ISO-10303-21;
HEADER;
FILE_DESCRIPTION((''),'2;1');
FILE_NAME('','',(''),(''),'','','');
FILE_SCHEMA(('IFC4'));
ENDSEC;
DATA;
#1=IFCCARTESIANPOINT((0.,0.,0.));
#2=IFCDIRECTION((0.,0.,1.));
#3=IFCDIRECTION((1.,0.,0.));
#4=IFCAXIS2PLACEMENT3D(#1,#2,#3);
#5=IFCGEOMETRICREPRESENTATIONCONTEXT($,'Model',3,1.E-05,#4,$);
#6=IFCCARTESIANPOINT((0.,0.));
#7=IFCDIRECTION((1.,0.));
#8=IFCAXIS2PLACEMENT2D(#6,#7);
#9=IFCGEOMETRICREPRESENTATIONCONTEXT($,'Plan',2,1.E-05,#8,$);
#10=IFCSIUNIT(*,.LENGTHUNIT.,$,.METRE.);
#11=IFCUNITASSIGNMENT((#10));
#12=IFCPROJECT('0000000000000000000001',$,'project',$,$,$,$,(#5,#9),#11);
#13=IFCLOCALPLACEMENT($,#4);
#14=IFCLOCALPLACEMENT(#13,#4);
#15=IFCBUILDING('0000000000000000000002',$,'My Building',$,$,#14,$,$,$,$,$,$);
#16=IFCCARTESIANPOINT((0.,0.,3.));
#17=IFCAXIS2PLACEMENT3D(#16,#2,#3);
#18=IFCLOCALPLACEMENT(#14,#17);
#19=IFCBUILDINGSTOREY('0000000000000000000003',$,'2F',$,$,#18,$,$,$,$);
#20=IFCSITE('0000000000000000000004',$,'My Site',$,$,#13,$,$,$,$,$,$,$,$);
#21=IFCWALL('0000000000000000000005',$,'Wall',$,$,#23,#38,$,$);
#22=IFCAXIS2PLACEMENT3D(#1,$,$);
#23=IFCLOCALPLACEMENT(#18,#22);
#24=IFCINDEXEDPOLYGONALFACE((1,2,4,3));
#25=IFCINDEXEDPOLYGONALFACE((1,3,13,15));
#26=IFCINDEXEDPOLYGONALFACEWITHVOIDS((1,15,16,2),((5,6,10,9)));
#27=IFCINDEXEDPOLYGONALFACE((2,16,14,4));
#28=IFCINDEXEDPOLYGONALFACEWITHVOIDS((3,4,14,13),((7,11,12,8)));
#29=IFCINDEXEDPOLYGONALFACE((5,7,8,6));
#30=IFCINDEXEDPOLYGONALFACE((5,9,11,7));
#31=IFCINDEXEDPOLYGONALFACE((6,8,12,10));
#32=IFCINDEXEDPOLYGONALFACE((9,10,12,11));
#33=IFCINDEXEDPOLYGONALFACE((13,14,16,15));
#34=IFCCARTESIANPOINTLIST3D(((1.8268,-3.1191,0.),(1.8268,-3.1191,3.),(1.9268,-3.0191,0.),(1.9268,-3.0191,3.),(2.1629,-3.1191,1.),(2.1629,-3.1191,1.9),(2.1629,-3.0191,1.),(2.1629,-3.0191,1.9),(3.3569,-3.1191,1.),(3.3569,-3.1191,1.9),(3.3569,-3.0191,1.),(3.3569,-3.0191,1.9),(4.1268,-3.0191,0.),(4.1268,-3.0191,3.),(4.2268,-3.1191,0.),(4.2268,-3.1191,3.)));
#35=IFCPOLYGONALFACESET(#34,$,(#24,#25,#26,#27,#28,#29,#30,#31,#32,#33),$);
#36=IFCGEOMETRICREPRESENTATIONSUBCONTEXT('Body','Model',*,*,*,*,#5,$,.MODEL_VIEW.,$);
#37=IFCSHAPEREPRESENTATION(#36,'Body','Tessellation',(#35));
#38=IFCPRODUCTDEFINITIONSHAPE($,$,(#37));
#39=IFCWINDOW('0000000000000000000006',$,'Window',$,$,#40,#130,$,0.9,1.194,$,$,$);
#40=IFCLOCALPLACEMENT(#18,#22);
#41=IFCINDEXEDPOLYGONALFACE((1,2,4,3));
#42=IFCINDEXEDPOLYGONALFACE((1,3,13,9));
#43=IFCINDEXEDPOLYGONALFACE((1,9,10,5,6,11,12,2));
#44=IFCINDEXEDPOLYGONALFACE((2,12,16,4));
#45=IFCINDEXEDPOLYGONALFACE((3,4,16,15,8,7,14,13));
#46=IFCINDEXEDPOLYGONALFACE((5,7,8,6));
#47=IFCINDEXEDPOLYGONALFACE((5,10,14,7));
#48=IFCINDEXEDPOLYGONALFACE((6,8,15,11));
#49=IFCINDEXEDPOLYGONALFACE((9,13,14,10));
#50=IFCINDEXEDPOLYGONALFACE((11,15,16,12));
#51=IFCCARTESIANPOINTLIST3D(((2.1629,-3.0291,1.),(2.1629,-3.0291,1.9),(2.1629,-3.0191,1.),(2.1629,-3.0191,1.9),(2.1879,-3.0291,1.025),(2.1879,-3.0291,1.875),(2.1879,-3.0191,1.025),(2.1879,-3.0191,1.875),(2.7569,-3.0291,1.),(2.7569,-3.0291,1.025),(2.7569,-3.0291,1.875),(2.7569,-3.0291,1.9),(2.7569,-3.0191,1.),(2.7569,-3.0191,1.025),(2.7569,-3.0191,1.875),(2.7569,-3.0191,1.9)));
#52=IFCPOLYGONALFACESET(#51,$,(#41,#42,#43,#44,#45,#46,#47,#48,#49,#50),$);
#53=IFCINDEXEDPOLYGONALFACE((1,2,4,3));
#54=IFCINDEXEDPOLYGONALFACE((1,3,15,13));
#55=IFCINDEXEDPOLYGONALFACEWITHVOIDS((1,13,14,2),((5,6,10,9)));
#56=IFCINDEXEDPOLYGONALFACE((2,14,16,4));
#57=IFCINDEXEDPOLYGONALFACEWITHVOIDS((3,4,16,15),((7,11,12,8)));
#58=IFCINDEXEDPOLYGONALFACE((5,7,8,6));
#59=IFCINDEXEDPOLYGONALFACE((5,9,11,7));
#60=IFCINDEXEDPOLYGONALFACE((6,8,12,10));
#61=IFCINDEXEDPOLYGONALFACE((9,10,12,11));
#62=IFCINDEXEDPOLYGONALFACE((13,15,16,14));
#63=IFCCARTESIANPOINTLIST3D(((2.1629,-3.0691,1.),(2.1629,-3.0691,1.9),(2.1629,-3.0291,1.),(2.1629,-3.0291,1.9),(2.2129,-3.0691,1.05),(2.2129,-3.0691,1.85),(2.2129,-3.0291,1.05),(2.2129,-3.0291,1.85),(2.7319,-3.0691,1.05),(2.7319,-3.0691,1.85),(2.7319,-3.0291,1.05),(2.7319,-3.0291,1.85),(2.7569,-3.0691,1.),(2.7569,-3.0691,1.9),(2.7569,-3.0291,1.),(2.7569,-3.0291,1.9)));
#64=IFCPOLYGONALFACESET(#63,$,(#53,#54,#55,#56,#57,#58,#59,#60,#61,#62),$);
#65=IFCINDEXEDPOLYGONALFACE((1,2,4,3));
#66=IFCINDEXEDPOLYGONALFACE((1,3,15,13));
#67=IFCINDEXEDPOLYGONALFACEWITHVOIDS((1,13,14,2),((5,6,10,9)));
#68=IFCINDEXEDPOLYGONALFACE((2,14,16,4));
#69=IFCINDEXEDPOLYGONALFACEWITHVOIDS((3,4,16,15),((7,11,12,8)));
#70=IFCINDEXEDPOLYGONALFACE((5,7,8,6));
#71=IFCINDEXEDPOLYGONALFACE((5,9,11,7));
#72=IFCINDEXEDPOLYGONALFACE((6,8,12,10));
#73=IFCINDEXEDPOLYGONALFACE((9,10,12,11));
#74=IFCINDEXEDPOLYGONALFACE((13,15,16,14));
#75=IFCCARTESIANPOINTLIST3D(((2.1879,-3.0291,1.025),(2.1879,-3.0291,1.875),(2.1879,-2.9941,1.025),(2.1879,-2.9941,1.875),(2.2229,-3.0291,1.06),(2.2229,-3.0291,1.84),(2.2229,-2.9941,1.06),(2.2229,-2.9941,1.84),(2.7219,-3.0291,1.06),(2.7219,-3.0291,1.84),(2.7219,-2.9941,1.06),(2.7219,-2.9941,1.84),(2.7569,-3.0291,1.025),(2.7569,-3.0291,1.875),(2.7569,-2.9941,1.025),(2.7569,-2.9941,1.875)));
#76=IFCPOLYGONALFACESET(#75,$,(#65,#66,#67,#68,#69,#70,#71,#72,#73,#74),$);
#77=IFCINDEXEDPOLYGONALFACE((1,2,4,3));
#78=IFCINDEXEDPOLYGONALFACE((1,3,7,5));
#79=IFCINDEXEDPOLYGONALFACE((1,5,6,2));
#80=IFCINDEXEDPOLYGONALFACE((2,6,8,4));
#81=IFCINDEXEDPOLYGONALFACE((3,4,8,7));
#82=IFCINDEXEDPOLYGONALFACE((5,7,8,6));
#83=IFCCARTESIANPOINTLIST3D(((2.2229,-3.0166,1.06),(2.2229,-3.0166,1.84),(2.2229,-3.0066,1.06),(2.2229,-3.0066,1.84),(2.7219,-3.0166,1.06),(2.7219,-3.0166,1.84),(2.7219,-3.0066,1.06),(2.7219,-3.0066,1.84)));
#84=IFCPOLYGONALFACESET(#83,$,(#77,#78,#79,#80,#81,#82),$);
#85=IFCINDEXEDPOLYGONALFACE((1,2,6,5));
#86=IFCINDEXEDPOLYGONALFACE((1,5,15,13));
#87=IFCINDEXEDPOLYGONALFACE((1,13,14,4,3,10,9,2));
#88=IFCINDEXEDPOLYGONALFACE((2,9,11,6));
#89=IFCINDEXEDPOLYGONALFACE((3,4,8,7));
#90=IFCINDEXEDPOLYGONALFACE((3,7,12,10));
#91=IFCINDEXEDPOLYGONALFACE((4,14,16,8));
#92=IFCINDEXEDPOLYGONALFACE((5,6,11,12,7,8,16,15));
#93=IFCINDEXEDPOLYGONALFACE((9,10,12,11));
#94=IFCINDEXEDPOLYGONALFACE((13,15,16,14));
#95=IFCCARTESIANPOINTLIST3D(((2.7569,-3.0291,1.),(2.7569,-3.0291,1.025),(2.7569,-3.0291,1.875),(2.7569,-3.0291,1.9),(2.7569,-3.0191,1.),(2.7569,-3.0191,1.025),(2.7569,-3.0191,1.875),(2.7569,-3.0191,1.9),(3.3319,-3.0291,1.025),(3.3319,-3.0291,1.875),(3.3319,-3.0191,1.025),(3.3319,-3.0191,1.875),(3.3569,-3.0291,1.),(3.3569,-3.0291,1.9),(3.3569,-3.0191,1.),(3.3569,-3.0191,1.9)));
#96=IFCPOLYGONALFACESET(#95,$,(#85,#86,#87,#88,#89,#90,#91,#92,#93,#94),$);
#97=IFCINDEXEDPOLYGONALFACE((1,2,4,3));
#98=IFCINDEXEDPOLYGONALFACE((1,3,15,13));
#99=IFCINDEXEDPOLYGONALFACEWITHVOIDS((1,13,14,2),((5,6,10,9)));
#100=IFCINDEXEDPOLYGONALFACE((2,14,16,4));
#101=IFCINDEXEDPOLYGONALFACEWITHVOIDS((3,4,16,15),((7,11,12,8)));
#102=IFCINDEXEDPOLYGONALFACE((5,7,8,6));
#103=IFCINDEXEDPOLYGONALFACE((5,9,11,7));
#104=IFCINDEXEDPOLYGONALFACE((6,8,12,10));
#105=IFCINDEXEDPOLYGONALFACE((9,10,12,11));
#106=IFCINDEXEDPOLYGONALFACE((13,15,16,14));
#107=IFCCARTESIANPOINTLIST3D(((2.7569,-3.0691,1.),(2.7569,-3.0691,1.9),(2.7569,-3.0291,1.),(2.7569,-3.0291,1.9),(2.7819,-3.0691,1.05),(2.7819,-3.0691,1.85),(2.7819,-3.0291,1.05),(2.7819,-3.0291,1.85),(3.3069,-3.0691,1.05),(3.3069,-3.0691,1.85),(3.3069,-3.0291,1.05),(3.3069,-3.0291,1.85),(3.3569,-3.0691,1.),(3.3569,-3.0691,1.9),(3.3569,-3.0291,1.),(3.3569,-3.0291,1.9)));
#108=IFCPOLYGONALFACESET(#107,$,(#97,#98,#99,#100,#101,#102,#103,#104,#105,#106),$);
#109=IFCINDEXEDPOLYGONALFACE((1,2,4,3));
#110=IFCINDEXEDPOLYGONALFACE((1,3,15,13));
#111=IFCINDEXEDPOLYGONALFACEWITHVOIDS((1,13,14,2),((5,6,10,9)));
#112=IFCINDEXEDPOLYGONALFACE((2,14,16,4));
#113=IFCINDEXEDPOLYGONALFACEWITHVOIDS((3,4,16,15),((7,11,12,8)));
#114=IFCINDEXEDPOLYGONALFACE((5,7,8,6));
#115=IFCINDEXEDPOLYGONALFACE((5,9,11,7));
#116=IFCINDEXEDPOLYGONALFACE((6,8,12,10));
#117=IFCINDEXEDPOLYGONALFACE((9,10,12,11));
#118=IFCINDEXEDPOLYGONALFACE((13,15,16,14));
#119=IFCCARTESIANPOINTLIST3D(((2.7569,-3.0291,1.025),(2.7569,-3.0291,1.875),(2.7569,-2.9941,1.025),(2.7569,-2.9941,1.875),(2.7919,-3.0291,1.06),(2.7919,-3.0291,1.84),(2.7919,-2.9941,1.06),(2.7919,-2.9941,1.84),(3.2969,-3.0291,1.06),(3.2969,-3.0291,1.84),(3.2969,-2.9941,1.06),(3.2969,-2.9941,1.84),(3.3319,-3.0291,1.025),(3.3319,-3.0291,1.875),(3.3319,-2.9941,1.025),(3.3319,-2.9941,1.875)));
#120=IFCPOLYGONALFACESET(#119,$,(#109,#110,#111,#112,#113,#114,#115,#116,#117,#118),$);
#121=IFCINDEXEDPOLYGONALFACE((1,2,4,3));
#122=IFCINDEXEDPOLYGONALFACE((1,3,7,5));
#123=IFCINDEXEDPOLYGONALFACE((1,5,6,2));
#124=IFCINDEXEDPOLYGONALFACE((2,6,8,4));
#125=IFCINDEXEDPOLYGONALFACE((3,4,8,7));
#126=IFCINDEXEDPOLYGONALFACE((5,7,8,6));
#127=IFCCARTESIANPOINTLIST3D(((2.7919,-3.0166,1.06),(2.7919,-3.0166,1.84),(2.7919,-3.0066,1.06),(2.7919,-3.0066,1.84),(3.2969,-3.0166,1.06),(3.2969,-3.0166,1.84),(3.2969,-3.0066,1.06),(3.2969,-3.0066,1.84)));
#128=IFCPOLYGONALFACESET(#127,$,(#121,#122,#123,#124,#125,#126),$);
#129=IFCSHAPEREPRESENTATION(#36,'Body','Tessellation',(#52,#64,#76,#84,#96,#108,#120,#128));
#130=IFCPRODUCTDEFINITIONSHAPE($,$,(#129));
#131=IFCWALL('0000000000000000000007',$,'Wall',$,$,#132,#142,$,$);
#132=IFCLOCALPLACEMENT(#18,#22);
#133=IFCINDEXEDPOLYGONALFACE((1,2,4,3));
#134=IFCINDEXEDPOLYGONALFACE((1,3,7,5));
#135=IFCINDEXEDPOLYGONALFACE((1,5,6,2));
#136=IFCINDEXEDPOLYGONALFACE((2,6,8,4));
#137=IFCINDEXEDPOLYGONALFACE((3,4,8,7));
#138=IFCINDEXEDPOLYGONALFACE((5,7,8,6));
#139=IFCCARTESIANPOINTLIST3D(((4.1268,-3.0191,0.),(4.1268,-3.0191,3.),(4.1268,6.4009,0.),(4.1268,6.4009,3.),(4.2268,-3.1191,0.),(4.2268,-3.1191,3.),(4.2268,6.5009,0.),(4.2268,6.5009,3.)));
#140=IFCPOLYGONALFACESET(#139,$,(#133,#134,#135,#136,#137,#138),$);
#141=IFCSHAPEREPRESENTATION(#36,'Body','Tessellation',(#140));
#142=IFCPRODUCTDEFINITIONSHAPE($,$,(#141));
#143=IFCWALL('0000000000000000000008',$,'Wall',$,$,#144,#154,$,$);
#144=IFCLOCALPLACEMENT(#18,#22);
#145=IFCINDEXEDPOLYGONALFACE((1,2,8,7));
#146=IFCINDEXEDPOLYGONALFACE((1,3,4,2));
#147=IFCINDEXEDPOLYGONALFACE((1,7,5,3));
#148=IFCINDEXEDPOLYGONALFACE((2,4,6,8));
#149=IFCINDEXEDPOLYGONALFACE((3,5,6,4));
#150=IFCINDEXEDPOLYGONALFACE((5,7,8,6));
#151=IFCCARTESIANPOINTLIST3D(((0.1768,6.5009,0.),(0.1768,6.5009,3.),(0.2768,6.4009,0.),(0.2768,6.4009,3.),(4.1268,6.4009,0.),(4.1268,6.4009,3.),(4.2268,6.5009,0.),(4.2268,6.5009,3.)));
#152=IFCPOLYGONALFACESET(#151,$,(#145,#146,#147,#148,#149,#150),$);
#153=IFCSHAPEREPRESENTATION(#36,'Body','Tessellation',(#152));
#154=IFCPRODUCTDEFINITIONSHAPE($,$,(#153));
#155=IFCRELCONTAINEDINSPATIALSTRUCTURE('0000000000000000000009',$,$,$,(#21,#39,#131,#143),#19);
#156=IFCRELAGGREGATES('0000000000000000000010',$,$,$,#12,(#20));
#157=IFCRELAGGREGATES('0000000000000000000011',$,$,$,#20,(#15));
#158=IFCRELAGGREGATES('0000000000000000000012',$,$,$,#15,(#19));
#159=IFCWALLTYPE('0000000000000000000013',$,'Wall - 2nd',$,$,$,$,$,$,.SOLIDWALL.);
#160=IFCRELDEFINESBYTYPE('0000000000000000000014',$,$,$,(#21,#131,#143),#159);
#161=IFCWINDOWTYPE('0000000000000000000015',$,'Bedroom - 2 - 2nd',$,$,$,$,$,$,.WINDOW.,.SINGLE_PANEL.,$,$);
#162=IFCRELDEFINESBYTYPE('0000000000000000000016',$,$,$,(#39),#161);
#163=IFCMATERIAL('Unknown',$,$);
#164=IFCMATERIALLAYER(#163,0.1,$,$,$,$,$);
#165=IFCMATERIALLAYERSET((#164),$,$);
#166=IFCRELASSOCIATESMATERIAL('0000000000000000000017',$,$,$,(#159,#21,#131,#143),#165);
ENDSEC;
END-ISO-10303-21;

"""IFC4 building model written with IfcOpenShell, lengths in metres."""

from ifc_helpers import new_model, entity, si_unit, frame, origin_with_axes, origin_2d_with_axis, place, context, subcontext, project, spatial, line, indexed_curve, outline, extrude, shape, source, transform, mapped, material, layer, layer_set, layer_usage, type_object, type_shapes, element, fill, save


model = new_model("IFC4")

# Units and contexts
model_context = context("Model", 3, precision=1e-05, world=origin_with_axes())
plan_context = context("Plan", 2, precision=1e-05, world=origin_2d_with_axis())
body_context_1 = subcontext(model_context, "Body", "Model", "MODEL_VIEW")
body_context_2 = subcontext(plan_context, "Body", "Plan", "PLAN_VIEW")
ifc_project = project(units=[si_unit("LENGTHUNIT", "METRE")], contexts=[model_context, plan_context])

# Site, building, storey
site_placement = place(None, origin_with_axes())
site = spatial("IfcSite", under=ifc_project, at=site_placement, Name="My Site")
building_placement = place(site_placement, origin_with_axes())
building = spatial("IfcBuilding", under=site, at=building_placement, Name="My Building")
storey_placement = place(building_placement, frame((0.0, 0.0, 3.0), z_axis=(0.0, 0.0, 1.0), x_axis=(1.0, 0.0, 0.0)))
storey = spatial("IfcBuildingStorey", under=building, at=storey_placement, Name="2F")

# Shared definitions
ifc_material = material(Name="Unknown")

# Shared definitions
ifc_layer_1 = layer(ifc_material, 0.1)
ifc_layer_set_1 = layer_set([ifc_layer_1])
wall_type = type_object("IfcWallType", Name="Wall - 2nd", PredefinedType="SOLIDWALL", material=ifc_layer_set_1)

# Wall, opening, window
ifc_layer_usage_1 = layer_usage(ifc_layer_set_1, "AXIS2", "POSITIVE", 0.0)
wall_1_placement = place(storey_placement, frame((1.8268, -3.1191, 0.0), z_axis=(0.0, 0.0, 1.0), x_axis=(1.0, 0.0, 0.0)))
wall_1 = element("IfcWall", 1, at=wall_1_placement, inside=storey, type_object=wall_type, material=ifc_layer_usage_1, Name="Wall", context=body_context_1, shape_type="SweptSolid", body=[
    extrude(outline(indexed_curve([(0.0, 0.0), (0.1, 0.1), (2.3, 0.1), (2.4, 0.0)], segments=[line(1, 2, 3, 4, 1)])), origin_with_axes(), (0.0, 0.0, 1.0), 3.0),
])
shared_shape_1 = source(origin_with_axes(), body_context_1, "Body", "SweptSolid", [
    extrude(outline(indexed_curve([(0.0, 0.0), (1.194, 0.0), (1.194, 0.9), (0.0, 0.9)], segments=[line(1, 2, 3, 4, 1)])), frame((0.0, -0.6, 0.0), z_axis=(0.0, -1.0, 0.0), x_axis=(1.0, 0.0, 0.0)), (0.0, 0.0, -1.0), 1.2),
])
opening_1_placement = place(wall_1_placement, frame((0.336, 0.0, 1.0), z_axis=(0.0, 0.0, 1.0), x_axis=(1.0, 0.0, 0.0)))
opening_1 = element("IfcOpeningElement", 2, at=opening_1_placement, cuts=wall_1, PredefinedType="OPENING", context=body_context_1, shape_type="MappedRepresentation", body=[
    mapped(shared_shape_1, transform((0.0, 0.0, 0.0), x_axis=(1.0, 0.0, 0.0), y_axis=(0.0, 1.0, 0.0), z_axis=(0.0, 0.0, 1.0), scale=1.0)),
])
window_type_1 = type_object("IfcWindowType", Name="Bedroom - 2 - 2nd", PartitioningType="SINGLE_PANEL", PredefinedType="WINDOW")
shared_shape_2 = source(origin_with_axes(), body_context_1, "Body", "SweptSolid", [
    extrude(outline(indexed_curve([(0.5941, 0.0), (0.0, 0.0), (0.0, 0.9), (0.5941, 0.9), (0.5941, 0.875), (0.025, 0.875), (0.025, 0.025), (0.5941, 0.025)], segments=[line(1, 2, 3, 4, 5, 6, 7, 8, 1)])), frame((0.0, 0.09, 0.0), z_axis=(0.0, -1.0, 0.0), x_axis=(1.0, 0.0, 0.0)), (0.0, 0.0, -1.0), 0.01),
    extrude(outline(indexed_curve([(0.0, 0.0), (0.5941, 0.0), (0.5941, 0.9), (0.0, 0.9)], segments=[line(1, 2, 3, 4, 1)]), holes=[indexed_curve([(0.05, 0.05), (0.5691, 0.05), (0.5691, 0.85), (0.05, 0.85)], segments=[line(1, 2, 3, 4, 1)])]), frame((0.0, 0.05, 0.0), z_axis=(0.0, -1.0, 0.0), x_axis=(1.0, 0.0, 0.0)), (0.0, 0.0, -1.0), 0.04),
    extrude(outline(indexed_curve([(0.0, 0.0), (0.5691, 0.0), (0.5691, 0.85), (0.0, 0.85)], segments=[line(1, 2, 3, 4, 1)]), holes=[indexed_curve([(0.035, 0.035), (0.5341, 0.035), (0.5341, 0.815), (0.035, 0.815)], segments=[line(1, 2, 3, 4, 1)])]), frame((0.025, 0.09, 0.025), z_axis=(0.0, -1.0, 0.0), x_axis=(1.0, 0.0, 0.0)), (0.0, 0.0, -1.0), 0.035),
    extrude(outline(indexed_curve([(0.035, 0.035), (0.5341, 0.035), (0.5341, 0.815), (0.035, 0.815)], segments=[line(1, 2, 3, 4, 1)])), frame((0.025, 0.1025, 0.025), z_axis=(0.0, -1.0, 0.0), x_axis=(1.0, 0.0, 0.0)), (0.0, 0.0, -1.0), 0.01),
    extrude(outline(indexed_curve([(0.0, 0.9), (0.5999, 0.9), (0.5999, 0.0), (0.0, 0.0), (0.0, 0.025), (0.5749, 0.025), (0.5749, 0.875), (0.0, 0.875)], segments=[line(1, 2, 3, 4, 5, 6, 7, 8, 1)])), frame((0.5941, 0.09, 0.0), z_axis=(0.0, -1.0, 0.0), x_axis=(1.0, 0.0, 0.0)), (0.0, 0.0, -1.0), 0.01),
    extrude(outline(indexed_curve([(0.0, 0.0), (0.5999, 0.0), (0.5999, 0.9), (0.0, 0.9)], segments=[line(1, 2, 3, 4, 1)]), holes=[indexed_curve([(0.025, 0.05), (0.5499, 0.05), (0.5499, 0.85), (0.025, 0.85)], segments=[line(1, 2, 3, 4, 1)])]), frame((0.5941, 0.05, 0.0), z_axis=(0.0, -1.0, 0.0), x_axis=(1.0, 0.0, 0.0)), (0.0, 0.0, -1.0), 0.04),
    extrude(outline(indexed_curve([(0.0, 0.0), (0.5749, 0.0), (0.5749, 0.85), (0.0, 0.85)], segments=[line(1, 2, 3, 4, 1)]), holes=[indexed_curve([(0.035, 0.035), (0.5399, 0.035), (0.5399, 0.815), (0.035, 0.815)], segments=[line(1, 2, 3, 4, 1)])]), frame((0.5941, 0.09, 0.025), z_axis=(0.0, -1.0, 0.0), x_axis=(1.0, 0.0, 0.0)), (0.0, 0.0, -1.0), 0.035),
    extrude(outline(indexed_curve([(0.035, 0.035), (0.5399, 0.035), (0.5399, 0.815), (0.035, 0.815)], segments=[line(1, 2, 3, 4, 1)])), frame((0.5941, 0.1025, 0.025), z_axis=(0.0, -1.0, 0.0), x_axis=(1.0, 0.0, 0.0)), (0.0, 0.0, -1.0), 0.01),
])
shared_shape_3 = source(origin_with_axes(), body_context_2, "Body", "Curve2D", [
    entity("IfcIndexedPolyCurve", entity("IfcCartesianPointList2D", [[0.05, 0.05], [0.5691, 0.05]])),
    entity("IfcIndexedPolyCurve", entity("IfcCartesianPointList2D", [[0.0, 0.1], [0.025, 0.1], [0.025, 0.09], [0.05, 0.09], [0.05, 0.05], [0.0, 0.05]]), [entity("IfcLineIndex", [1, 2, 3, 4, 5, 6, 1])]),
    entity("IfcIndexedPolyCurve", entity("IfcCartesianPointList2D", [[0.5941, 0.1], [0.5941, 0.1], [0.5941, 0.09], [0.5691, 0.09], [0.5691, 0.05], [0.5941, 0.05]])),
    entity("IfcIndexedPolyCurve", entity("IfcCartesianPointList2D", [[0.025, 0.09], [0.06, 0.09], [0.06, 0.125], [0.025, 0.125]]), [entity("IfcLineIndex", [1, 2, 3, 4, 1])]),
    entity("IfcIndexedPolyCurve", entity("IfcCartesianPointList2D", [[0.5941, 0.09], [0.5591, 0.09], [0.5591, 0.125], [0.5941, 0.125]]), [entity("IfcLineIndex", [1, 2, 3, 4, 1])]),
    entity("IfcIndexedPolyCurve", entity("IfcCartesianPointList2D", [[0.06, 0.09], [0.5591, 0.09]])),
    entity("IfcIndexedPolyCurve", entity("IfcCartesianPointList2D", [[0.06, 0.125], [0.5591, 0.125]])),
    entity("IfcIndexedPolyCurve", entity("IfcCartesianPointList2D", [[0.06, 0.1075], [0.5591, 0.1075]])),
    entity("IfcIndexedPolyCurve", entity("IfcCartesianPointList2D", [[0.6191, 0.05], [1.144, 0.05]])),
    entity("IfcIndexedPolyCurve", entity("IfcCartesianPointList2D", [[0.5941, 0.1], [0.5941, 0.1], [0.5941, 0.09], [0.6191, 0.09], [0.6191, 0.05], [0.5941, 0.05]])),
    entity("IfcIndexedPolyCurve", entity("IfcCartesianPointList2D", [[1.194, 0.1], [1.169, 0.1], [1.169, 0.09], [1.144, 0.09], [1.144, 0.05], [1.194, 0.05]]), [entity("IfcLineIndex", [1, 2, 3, 4, 5, 6, 1])]),
    entity("IfcIndexedPolyCurve", entity("IfcCartesianPointList2D", [[0.5941, 0.09], [0.6291, 0.09], [0.6291, 0.125], [0.5941, 0.125]]), [entity("IfcLineIndex", [1, 2, 3, 4, 1])]),
    entity("IfcIndexedPolyCurve", entity("IfcCartesianPointList2D", [[1.169, 0.09], [1.134, 0.09], [1.134, 0.125], [1.169, 0.125]]), [entity("IfcLineIndex", [1, 2, 3, 4, 1])]),
    entity("IfcIndexedPolyCurve", entity("IfcCartesianPointList2D", [[0.6291, 0.09], [1.134, 0.09]])),
    entity("IfcIndexedPolyCurve", entity("IfcCartesianPointList2D", [[0.6291, 0.125], [1.134, 0.125]])),
    entity("IfcIndexedPolyCurve", entity("IfcCartesianPointList2D", [[0.6291, 0.1075], [1.134, 0.1075]])),
])
type_shapes(window_type_1, [shared_shape_2, shared_shape_3])
window_1_placement = place(opening_1_placement, frame((0.0, 0.0, 0.0), z_axis=(0.0, 0.0, 1.0), x_axis=(1.0, 0.0, 0.0)))
window_1 = element("IfcWindow", 3, at=window_1_placement, inside=storey, type_object=window_type_1, Name="Window", OverallHeight=0.9, OverallWidth=1.194, shapes=[
    shape(body_context_1, "Body", "MappedRepresentation", [mapped(shared_shape_2, transform((0.0, 0.0, 0.0), x_axis=(1.0, 0.0, 0.0), y_axis=(0.0, 1.0, 0.0), z_axis=(0.0, 0.0, 1.0), scale=1.0))]),
    shape(body_context_2, "Body", "MappedRepresentation", [mapped(shared_shape_3, transform((0.0, 0.0, 0.0), x_axis=(1.0, 0.0, 0.0), y_axis=(0.0, 1.0, 0.0), z_axis=(0.0, 0.0, 1.0), scale=1.0))]),
])
fill(opening_1, window_1)

# Walls
ifc_layer_usage_2 = layer_usage(ifc_layer_set_1, "AXIS2", "POSITIVE", 0.0)
wall_2_placement = place(storey_placement, frame((4.2268, -3.1191, 0.0), z_axis=(0.0, 0.0, 1.0), x_axis=(0.0, 1.0, 0.0)))
element("IfcWall", 4, at=wall_2_placement, inside=storey, type_object=wall_type, material=ifc_layer_usage_2, Name="Wall", context=body_context_1, shape_type="SweptSolid", body=[
    extrude(outline(indexed_curve([(0.0, 0.0), (0.1, 0.1), (9.52, 0.1), (9.62, 0.0)], segments=[line(1, 2, 3, 4, 1)])), origin_with_axes(), (0.0, 0.0, 1.0), 3.0),
])
ifc_layer_usage_3 = layer_usage(ifc_layer_set_1, "AXIS2", "POSITIVE", 0.0)
wall_3_placement = place(storey_placement, frame((4.2268, 6.5009, 0.0), z_axis=(0.0, 0.0, 1.0), x_axis=(-1.0, 0.0, 0.0)))
element("IfcWall", 5, at=wall_3_placement, inside=storey, type_object=wall_type, material=ifc_layer_usage_3, Name="Wall", context=body_context_1, shape_type="SweptSolid", body=[
    extrude(outline(indexed_curve([(0.0, 0.0), (0.1, 0.1), (3.95, 0.1), (4.05, 0.0)], segments=[line(1, 2, 3, 4, 1)])), origin_with_axes(), (0.0, 0.0, 1.0), 3.0),
])

save(model, "model.ifc")
